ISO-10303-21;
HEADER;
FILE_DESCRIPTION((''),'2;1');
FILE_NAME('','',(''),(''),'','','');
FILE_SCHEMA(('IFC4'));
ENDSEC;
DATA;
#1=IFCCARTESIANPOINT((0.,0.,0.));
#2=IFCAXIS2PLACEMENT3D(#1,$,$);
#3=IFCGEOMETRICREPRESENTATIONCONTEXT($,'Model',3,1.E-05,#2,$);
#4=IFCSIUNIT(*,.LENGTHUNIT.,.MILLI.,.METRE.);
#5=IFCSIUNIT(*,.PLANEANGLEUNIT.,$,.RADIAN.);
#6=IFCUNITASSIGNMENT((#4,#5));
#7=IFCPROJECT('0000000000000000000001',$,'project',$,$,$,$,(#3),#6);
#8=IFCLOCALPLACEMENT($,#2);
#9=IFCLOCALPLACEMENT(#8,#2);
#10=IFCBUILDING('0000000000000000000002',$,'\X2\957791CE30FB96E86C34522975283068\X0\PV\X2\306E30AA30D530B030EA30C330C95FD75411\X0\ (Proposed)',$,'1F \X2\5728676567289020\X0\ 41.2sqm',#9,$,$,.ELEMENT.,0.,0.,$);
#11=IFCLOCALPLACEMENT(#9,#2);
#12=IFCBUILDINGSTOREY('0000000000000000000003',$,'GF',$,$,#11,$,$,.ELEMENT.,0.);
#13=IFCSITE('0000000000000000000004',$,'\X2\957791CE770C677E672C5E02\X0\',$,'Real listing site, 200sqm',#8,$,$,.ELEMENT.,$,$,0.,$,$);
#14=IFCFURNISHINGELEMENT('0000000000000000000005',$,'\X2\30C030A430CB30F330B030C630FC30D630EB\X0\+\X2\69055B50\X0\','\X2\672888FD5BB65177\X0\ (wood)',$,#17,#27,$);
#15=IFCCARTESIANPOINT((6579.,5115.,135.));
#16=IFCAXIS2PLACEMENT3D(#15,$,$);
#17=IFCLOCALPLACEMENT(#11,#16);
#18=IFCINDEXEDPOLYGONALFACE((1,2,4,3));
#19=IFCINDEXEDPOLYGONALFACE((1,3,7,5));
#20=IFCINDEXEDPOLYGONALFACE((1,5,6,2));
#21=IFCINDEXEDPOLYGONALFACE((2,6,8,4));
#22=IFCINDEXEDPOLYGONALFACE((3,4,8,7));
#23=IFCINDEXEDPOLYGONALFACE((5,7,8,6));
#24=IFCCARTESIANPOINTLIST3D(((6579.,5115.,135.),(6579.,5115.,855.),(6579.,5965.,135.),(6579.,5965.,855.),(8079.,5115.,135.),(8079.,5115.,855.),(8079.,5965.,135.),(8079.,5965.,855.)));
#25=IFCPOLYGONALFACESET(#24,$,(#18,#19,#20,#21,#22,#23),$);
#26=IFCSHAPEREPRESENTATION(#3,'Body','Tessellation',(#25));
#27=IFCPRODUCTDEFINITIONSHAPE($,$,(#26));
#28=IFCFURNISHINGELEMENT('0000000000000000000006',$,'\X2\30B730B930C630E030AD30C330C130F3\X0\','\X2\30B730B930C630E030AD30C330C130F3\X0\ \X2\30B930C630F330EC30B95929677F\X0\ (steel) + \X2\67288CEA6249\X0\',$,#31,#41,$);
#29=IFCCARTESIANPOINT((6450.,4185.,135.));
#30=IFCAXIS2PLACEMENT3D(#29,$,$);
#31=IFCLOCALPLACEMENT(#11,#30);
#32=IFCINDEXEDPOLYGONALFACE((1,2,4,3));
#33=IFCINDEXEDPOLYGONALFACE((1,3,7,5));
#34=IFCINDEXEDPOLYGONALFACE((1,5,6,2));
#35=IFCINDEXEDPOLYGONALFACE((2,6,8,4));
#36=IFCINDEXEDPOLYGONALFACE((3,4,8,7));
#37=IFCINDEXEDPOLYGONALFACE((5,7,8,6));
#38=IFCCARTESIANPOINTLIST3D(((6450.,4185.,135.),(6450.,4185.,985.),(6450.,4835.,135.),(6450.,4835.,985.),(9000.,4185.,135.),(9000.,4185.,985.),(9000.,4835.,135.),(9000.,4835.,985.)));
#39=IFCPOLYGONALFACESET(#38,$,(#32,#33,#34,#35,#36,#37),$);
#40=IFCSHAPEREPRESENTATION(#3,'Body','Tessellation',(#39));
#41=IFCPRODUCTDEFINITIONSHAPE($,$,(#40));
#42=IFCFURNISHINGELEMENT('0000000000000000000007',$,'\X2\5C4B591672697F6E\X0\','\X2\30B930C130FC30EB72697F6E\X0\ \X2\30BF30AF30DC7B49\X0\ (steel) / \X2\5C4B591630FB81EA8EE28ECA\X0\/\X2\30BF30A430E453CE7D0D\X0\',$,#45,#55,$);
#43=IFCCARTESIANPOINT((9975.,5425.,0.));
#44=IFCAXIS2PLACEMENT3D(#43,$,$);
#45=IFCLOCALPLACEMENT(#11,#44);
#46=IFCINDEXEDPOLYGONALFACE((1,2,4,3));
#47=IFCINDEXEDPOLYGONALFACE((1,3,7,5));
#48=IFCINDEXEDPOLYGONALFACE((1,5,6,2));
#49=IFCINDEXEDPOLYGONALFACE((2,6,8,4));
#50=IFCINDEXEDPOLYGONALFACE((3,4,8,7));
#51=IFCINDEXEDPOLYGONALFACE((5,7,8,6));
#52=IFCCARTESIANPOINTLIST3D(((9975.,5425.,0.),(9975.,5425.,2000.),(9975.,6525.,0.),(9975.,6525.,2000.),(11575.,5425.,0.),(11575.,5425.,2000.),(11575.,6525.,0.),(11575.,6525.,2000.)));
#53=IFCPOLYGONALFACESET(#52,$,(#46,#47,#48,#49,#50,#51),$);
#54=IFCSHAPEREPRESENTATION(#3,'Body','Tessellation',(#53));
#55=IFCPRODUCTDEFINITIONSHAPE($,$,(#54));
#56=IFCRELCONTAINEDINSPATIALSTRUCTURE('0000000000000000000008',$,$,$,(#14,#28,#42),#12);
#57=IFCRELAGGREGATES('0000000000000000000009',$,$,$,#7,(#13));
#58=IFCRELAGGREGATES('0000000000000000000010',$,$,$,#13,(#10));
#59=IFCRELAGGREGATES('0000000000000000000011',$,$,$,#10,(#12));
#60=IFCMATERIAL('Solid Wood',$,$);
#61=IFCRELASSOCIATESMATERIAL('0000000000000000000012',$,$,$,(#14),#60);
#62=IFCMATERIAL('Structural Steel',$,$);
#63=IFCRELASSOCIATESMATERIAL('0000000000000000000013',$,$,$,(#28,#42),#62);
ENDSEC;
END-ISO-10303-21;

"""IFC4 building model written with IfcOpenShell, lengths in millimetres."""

from ifc_helpers import new_model, si_unit, frame, frame_2d, origin, place, context, project, spatial, rectangle, extrude, material, element, save


model = new_model("IFC4")

# Units and contexts
model_context = context("Model", 3, precision=1e-05, world=origin())
ifc_project = project(units=[si_unit("LENGTHUNIT", "METRE", prefix="MILLI"), si_unit("PLANEANGLEUNIT", "RADIAN")], contexts=[model_context])

# Site, building, storey
site_placement = place(None, origin())
site = spatial("IfcSite", under=ifc_project, at=site_placement, Name="長野県松本市", ObjectType="Real listing site, 200sqm", CompositionType="ELEMENT", RefElevation=0.0)
building_placement = place(site_placement, origin())
building = spatial("IfcBuilding", under=site, at=building_placement, Name="長野・雨水利用とPVのオフグリッド志向 (Proposed)", ObjectType="1F 在来木造 41.2sqm", CompositionType="ELEMENT", ElevationOfRefHeight=0.0, ElevationOfTerrain=0.0)
storey_placement = place(building_placement, origin())
storey = spatial("IfcBuildingStorey", under=building, at=storey_placement, Name="GF", CompositionType="ELEMENT", Elevation=0.0)

# Shared definitions
ifc_material_1 = material(Name="Solid Wood")

# Shared definitions
ifc_material_2 = material(Name="Structural Steel")

# Furnishing elements
furnishing_1_placement = place(storey_placement, frame((6579.0, 5115.0, 135.0)))
element("IfcFurnishingElement", 1, at=furnishing_1_placement, inside=storey, material=ifc_material_1, Name="ダイニングテーブル+椅子", Description="木製家具 (wood)", context=model_context, shape_type="SweptSolid", body=[
    extrude(rectangle(XDim=1500.0, YDim=850.0, at=frame_2d((750.0, 425.0))), frame((6579.0, 5115.0, 135.0)), (0.0, 0.0, 1.0), 720.0),
])
furnishing_2_placement = place(storey_placement, frame((6450.0, 4185.0, 135.0)))
element("IfcFurnishingElement", 2, at=furnishing_2_placement, inside=storey, material=ifc_material_2, Name="システムキッチン", Description="システムキッチン ステンレス天板 (steel) + 木質扉", context=model_context, shape_type="SweptSolid", body=[
    extrude(rectangle(XDim=2550.0, YDim=650.0, at=frame_2d((1275.0, 325.0))), frame((6450.0, 4185.0, 135.0)), (0.0, 0.0, 1.0), 850.0),
])
furnishing_3_placement = place(storey_placement, frame((9975.0, 5425.0, 0.0)))
element("IfcFurnishingElement", 3, at=furnishing_3_placement, inside=storey, material=ifc_material_2, Name="屋外物置", Description="スチール物置 タクボ等 (steel) / 屋外・自転車/タイヤ収納", context=model_context, shape_type="SweptSolid", body=[
    extrude(rectangle(XDim=1600.0, YDim=1100.0, at=frame_2d((800.0, 550.0))), frame((9975.0, 5425.0, 0.0)), (0.0, 0.0, 1.0), 2000.0),
])

save(model, "model.ifc")
